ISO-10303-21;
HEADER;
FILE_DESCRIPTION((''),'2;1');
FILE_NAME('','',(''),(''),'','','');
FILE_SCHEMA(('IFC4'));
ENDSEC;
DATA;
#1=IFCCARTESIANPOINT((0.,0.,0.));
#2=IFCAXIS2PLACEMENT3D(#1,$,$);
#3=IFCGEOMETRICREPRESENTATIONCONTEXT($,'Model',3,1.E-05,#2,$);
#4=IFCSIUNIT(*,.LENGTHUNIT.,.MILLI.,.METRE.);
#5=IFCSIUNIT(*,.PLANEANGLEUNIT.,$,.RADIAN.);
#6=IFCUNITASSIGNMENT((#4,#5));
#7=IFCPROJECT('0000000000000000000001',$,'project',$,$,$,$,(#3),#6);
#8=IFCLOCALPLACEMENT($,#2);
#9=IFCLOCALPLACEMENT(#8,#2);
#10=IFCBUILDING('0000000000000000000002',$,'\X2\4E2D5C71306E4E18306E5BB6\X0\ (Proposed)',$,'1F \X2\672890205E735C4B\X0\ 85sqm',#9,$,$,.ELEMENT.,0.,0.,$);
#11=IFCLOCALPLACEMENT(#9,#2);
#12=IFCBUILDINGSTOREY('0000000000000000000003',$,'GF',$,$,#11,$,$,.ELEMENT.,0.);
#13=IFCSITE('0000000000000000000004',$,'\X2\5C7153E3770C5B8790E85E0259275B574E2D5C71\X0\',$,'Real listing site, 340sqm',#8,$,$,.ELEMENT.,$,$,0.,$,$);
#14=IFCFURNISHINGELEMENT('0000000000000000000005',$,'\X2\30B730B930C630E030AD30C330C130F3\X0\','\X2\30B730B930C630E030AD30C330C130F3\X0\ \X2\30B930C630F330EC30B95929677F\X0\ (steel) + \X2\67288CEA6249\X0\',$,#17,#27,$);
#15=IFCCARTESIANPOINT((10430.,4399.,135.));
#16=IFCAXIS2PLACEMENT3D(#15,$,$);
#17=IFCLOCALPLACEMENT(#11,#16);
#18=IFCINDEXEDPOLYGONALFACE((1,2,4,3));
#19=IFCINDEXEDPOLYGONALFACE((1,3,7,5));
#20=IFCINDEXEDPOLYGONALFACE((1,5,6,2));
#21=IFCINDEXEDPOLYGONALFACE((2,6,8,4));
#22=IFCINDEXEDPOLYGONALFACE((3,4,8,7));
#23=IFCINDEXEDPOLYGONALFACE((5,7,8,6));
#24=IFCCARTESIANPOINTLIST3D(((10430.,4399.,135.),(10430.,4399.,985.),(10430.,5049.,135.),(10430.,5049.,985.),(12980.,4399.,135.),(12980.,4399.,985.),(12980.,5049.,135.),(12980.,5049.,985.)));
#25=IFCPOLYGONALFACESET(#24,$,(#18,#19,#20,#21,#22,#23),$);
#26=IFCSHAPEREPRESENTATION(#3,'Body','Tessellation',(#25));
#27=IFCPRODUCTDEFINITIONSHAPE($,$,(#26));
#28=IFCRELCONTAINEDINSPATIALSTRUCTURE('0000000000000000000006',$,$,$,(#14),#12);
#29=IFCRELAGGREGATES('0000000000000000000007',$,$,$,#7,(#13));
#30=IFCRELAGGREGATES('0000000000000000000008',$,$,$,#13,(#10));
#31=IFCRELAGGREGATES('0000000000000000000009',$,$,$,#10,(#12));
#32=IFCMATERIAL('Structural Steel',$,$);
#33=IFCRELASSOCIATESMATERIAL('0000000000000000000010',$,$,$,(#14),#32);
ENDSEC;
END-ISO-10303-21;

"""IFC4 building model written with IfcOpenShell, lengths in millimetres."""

from ifc_helpers import new_model, si_unit, frame, frame_2d, origin, place, context, project, spatial, rectangle, extrude, material, element, save


model = new_model("IFC4")

# Units and contexts
model_context = context("Model", 3, precision=1e-05, world=origin())
ifc_project = project(units=[si_unit("LENGTHUNIT", "METRE", prefix="MILLI"), si_unit("PLANEANGLEUNIT", "RADIAN")], contexts=[model_context])

# Site, building, storey
site_placement = place(None, origin())
site = spatial("IfcSite", under=ifc_project, at=site_placement, Name="山口県宇部市大字中山", ObjectType="Real listing site, 340sqm", CompositionType="ELEMENT", RefElevation=0.0)
building_placement = place(site_placement, origin())
building = spatial("IfcBuilding", under=site, at=building_placement, Name="中山の丘の家 (Proposed)", ObjectType="1F 木造平屋 85sqm", CompositionType="ELEMENT", ElevationOfRefHeight=0.0, ElevationOfTerrain=0.0)
storey_placement = place(building_placement, origin())
storey = spatial("IfcBuildingStorey", under=building, at=storey_placement, Name="GF", CompositionType="ELEMENT", Elevation=0.0)

# Furnishing element
ifc_material_1 = material(Name="Structural Steel")
furnishing_1_placement = place(storey_placement, frame((10430.0, 4399.0, 135.0)))
element("IfcFurnishingElement", 1, at=furnishing_1_placement, inside=storey, material=ifc_material_1, Name="システムキッチン", Description="システムキッチン ステンレス天板 (steel) + 木質扉", context=model_context, shape_type="SweptSolid", body=[
    extrude(rectangle(XDim=2550.0, YDim=650.0, at=frame_2d((1275.0, 325.0))), frame((10430.0, 4399.0, 135.0)), (0.0, 0.0, 1.0), 850.0),
])

save(model, "model.ifc")
